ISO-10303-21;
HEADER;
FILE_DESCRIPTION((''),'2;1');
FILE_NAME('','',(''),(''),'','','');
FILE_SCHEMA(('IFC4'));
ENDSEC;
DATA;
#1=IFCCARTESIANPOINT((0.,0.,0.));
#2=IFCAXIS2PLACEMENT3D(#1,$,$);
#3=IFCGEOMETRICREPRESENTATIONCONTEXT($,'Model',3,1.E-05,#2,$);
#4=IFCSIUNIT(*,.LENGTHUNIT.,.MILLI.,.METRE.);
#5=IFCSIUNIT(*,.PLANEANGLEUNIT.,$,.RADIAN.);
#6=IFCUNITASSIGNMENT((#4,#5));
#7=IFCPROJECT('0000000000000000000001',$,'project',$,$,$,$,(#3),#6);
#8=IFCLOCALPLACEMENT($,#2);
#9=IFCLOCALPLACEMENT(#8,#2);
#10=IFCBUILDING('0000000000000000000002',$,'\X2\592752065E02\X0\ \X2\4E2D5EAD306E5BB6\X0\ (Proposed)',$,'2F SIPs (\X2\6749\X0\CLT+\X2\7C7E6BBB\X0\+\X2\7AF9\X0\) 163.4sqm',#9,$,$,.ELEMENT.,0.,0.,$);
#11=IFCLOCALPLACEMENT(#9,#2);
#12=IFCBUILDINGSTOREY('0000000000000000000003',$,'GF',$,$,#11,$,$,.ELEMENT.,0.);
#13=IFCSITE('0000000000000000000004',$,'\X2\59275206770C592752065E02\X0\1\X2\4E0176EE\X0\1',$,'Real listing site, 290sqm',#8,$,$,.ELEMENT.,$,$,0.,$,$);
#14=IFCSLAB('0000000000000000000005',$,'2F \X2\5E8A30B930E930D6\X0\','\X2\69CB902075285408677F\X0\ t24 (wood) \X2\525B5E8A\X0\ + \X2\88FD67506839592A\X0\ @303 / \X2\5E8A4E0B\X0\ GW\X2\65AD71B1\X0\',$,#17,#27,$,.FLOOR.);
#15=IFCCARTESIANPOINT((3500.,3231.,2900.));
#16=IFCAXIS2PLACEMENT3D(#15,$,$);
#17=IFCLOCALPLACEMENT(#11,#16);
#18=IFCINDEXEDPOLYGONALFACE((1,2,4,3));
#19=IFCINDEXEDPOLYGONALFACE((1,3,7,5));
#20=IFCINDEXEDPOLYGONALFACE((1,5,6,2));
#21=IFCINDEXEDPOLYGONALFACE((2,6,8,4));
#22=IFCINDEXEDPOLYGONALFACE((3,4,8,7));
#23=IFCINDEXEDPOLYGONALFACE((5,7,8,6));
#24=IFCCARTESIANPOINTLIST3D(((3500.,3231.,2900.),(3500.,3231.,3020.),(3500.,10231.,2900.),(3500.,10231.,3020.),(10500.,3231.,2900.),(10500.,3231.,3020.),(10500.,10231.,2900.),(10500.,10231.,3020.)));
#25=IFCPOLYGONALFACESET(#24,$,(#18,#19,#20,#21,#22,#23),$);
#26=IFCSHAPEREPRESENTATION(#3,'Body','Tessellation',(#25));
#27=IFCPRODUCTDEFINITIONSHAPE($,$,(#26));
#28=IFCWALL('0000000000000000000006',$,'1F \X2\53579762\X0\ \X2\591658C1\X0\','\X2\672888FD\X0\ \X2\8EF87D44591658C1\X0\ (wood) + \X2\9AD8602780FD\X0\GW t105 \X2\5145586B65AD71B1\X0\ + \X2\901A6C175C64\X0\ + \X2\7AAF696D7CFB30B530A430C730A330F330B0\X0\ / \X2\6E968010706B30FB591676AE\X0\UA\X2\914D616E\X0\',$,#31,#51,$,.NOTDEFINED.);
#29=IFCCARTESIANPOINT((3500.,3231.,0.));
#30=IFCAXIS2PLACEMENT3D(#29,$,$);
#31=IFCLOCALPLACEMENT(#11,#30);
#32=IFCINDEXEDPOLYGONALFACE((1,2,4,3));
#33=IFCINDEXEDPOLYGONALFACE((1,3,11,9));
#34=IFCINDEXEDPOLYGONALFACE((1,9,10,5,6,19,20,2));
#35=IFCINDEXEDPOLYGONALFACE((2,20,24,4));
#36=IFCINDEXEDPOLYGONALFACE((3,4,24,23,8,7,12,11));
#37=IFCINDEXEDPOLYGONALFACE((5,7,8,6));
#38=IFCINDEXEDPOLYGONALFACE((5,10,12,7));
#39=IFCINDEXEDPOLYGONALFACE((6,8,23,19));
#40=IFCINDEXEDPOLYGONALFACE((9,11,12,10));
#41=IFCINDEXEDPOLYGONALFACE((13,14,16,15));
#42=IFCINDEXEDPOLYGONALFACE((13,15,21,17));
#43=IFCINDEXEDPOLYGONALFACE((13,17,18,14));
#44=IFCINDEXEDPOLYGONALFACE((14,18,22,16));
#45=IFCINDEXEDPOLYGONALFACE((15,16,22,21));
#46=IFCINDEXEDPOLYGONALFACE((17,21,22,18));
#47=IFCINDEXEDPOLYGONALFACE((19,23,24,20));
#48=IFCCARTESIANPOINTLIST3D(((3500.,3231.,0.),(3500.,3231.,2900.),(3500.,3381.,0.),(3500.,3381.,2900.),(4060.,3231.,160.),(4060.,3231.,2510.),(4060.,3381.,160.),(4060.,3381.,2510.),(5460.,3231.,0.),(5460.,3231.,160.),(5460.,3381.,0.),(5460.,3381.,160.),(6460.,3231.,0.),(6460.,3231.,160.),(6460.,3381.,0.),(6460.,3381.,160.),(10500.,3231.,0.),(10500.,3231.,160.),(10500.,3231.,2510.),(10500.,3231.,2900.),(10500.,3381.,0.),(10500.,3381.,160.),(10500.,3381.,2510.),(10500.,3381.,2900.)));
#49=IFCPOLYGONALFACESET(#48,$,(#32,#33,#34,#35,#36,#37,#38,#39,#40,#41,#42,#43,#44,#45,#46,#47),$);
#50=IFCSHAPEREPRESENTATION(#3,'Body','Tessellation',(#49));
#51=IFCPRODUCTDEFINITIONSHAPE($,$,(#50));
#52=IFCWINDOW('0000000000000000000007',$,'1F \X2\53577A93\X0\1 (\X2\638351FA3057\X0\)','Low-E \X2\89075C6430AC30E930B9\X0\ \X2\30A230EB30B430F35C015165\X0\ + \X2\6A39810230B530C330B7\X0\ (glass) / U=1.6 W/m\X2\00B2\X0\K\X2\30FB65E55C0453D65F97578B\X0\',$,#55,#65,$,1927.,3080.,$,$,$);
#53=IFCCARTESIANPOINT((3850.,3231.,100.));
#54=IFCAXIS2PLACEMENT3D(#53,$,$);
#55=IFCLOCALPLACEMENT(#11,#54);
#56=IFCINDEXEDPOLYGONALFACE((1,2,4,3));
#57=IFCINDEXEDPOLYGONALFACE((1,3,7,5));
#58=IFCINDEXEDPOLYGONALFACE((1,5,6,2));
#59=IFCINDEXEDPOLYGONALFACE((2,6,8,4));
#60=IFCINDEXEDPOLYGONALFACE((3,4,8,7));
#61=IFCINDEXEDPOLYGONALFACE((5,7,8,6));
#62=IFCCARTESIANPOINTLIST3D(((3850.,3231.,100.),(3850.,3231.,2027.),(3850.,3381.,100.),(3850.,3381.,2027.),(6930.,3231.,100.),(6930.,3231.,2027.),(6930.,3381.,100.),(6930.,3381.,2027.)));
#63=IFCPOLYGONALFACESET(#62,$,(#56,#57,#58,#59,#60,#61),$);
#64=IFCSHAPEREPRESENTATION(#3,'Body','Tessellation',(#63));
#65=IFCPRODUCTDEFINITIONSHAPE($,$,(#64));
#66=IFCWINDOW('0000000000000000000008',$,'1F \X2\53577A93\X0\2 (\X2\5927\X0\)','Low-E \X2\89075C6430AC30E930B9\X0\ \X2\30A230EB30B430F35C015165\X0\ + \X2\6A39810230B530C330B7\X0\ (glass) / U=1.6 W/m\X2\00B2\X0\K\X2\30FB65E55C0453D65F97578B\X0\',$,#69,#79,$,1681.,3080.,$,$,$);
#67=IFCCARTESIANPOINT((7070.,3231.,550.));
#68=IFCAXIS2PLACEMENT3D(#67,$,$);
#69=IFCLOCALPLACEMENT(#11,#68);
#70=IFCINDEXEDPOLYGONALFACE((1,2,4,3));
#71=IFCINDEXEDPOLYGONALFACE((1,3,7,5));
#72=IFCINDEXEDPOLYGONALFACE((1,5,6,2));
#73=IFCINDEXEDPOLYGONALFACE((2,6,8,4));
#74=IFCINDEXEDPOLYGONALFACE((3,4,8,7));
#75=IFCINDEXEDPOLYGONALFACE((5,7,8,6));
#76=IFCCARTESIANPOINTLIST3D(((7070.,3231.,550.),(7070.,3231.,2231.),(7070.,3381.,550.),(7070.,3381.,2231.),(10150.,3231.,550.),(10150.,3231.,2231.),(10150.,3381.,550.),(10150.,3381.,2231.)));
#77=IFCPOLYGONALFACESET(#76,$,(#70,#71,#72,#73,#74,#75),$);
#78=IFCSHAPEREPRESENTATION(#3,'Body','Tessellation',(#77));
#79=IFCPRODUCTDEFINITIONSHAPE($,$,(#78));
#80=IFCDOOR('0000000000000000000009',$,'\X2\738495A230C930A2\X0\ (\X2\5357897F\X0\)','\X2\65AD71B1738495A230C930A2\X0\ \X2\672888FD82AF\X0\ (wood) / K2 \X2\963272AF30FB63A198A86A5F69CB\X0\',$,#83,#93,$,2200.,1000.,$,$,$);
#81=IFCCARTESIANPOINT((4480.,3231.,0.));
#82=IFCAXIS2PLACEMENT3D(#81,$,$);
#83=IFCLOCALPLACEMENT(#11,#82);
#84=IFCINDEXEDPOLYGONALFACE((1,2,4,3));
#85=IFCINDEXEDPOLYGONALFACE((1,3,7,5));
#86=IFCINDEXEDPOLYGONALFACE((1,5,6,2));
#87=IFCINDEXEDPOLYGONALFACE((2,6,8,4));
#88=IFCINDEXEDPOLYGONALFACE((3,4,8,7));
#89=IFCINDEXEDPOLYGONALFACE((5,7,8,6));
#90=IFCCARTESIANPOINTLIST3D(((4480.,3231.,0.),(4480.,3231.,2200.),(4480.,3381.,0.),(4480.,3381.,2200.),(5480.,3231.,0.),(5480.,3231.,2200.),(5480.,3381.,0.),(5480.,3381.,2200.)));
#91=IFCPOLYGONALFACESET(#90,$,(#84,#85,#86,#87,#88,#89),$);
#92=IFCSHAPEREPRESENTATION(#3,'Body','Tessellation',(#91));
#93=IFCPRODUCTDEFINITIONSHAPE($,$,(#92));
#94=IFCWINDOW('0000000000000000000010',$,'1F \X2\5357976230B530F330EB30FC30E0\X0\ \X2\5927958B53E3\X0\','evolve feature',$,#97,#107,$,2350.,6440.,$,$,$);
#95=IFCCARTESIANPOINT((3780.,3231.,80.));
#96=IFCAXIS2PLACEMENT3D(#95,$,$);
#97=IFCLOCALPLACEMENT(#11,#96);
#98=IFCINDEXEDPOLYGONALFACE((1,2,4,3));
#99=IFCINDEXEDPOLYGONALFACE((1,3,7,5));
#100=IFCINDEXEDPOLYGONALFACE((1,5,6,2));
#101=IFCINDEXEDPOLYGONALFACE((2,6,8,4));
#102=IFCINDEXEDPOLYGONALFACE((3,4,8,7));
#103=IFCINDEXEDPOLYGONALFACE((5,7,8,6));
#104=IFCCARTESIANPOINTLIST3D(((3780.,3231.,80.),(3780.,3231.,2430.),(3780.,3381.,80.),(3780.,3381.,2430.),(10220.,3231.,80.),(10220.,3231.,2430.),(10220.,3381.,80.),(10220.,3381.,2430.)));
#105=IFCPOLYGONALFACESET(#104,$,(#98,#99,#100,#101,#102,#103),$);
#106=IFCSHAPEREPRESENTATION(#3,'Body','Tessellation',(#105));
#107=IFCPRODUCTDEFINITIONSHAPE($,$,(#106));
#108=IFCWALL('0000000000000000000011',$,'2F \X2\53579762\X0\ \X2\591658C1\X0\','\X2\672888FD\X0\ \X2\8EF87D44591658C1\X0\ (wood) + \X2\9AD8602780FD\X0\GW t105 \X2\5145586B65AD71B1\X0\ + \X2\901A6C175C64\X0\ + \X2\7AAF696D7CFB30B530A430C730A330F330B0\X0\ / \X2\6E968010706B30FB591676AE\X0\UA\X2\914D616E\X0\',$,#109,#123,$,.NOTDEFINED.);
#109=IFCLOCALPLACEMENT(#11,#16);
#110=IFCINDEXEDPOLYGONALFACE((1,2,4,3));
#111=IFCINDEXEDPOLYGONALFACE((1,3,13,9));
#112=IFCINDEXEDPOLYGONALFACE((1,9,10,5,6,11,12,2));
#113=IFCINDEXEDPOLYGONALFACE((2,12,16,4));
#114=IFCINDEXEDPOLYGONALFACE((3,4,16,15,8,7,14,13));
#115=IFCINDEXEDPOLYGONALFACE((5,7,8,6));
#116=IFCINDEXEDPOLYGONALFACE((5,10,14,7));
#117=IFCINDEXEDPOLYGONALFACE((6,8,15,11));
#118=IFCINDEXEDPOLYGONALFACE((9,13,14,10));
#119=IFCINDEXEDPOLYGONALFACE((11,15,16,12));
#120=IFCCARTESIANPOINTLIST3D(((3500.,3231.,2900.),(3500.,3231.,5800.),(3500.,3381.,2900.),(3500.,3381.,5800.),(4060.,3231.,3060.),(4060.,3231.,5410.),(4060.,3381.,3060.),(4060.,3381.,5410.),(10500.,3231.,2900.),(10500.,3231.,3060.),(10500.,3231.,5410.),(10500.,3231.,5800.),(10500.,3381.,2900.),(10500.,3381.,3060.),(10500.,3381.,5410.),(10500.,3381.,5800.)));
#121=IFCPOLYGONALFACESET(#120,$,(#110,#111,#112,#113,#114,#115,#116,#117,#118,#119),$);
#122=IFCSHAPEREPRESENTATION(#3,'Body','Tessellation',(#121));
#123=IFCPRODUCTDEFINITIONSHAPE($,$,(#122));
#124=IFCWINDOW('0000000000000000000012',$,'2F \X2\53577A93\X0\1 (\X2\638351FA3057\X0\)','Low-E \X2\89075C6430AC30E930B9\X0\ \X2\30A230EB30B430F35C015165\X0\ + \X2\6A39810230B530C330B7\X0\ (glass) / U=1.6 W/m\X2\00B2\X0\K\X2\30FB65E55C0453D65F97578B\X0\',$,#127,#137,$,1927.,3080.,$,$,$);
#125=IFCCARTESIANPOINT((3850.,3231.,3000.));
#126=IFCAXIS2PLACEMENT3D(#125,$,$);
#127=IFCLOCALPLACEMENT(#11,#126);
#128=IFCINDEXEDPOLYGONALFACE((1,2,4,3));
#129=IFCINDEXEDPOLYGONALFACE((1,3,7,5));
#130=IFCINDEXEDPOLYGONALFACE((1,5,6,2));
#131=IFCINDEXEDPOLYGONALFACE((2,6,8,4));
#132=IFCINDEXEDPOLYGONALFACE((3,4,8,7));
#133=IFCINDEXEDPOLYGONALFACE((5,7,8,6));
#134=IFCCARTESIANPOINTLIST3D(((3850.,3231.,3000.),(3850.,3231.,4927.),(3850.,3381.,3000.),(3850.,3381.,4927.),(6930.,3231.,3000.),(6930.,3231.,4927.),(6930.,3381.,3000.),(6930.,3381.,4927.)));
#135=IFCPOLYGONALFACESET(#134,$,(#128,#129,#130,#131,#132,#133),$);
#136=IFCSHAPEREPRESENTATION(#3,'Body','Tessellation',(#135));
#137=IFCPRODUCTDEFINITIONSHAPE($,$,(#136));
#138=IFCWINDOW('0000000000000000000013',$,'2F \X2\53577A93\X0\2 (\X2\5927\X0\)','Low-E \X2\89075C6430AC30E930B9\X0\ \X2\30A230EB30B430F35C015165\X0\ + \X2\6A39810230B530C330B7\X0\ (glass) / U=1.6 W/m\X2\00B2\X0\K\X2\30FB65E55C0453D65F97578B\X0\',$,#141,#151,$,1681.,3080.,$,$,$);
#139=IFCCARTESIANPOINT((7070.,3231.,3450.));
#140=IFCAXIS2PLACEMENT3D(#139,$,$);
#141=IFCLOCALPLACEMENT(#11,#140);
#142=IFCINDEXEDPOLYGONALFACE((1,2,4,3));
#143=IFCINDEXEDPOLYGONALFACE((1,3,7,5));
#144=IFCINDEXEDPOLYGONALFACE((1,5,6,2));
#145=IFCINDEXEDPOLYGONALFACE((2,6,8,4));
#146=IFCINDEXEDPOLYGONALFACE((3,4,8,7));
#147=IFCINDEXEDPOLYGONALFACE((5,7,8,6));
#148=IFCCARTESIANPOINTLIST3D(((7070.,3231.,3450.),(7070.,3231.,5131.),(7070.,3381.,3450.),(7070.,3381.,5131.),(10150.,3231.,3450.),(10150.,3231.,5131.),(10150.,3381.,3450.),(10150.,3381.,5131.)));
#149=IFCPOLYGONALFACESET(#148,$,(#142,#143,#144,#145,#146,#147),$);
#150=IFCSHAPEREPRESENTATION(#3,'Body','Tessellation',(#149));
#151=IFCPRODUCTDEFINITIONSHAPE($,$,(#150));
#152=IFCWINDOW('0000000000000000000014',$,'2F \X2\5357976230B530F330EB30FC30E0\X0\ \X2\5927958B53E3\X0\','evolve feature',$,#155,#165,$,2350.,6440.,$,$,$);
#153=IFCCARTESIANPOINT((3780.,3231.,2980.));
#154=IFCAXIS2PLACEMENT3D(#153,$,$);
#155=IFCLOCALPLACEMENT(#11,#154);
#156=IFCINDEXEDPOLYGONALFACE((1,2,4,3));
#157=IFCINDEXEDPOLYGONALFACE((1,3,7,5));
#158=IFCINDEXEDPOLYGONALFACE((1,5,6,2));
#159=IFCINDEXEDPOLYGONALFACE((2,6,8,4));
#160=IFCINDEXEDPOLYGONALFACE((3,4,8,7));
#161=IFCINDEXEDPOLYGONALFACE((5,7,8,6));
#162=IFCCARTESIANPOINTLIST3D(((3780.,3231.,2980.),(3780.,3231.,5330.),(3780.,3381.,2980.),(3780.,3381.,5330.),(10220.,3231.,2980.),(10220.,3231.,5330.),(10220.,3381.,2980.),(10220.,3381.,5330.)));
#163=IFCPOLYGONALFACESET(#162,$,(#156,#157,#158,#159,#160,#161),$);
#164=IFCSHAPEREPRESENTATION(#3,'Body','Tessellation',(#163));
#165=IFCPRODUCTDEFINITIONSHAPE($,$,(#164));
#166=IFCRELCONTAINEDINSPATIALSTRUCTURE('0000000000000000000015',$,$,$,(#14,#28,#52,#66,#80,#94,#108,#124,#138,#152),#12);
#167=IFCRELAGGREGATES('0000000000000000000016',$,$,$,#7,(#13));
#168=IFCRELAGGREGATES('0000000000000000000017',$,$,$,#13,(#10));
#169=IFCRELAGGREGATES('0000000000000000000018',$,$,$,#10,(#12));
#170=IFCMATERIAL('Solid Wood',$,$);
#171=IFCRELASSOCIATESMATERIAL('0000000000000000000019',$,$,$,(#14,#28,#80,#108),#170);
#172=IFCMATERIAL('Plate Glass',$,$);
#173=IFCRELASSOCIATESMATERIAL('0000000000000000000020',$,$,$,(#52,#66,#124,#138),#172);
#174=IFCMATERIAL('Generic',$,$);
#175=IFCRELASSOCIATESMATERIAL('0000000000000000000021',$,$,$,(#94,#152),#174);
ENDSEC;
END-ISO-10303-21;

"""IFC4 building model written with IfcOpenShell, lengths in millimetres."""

from ifc_helpers import new_model, si_unit, frame, frame_2d, origin, place, context, project, spatial, rectangle, extrude, material, element, fill, save


model = new_model("IFC4")

# Units and contexts
model_context = context("Model", 3, precision=1e-05, world=origin())
ifc_project = project(units=[si_unit("LENGTHUNIT", "METRE", prefix="MILLI"), si_unit("PLANEANGLEUNIT", "RADIAN")], contexts=[model_context])

# Site, building, storey
site_placement = place(None, origin())
site = spatial("IfcSite", under=ifc_project, at=site_placement, Name="大分県大分市1丁目1", ObjectType="Real listing site, 290sqm", CompositionType="ELEMENT", RefElevation=0.0)
building_placement = place(site_placement, origin())
building = spatial("IfcBuilding", under=site, at=building_placement, Name="大分市 中庭の家 (Proposed)", ObjectType="2F SIPs (杉CLT+籾殻+竹) 163.4sqm", CompositionType="ELEMENT", ElevationOfRefHeight=0.0, ElevationOfTerrain=0.0)
storey_placement = place(building_placement, origin())
storey = spatial("IfcBuildingStorey", under=building, at=storey_placement, Name="GF", CompositionType="ELEMENT", Elevation=0.0)

# Slab
ifc_material_1 = material(Name="Solid Wood")
slab_1_placement = place(storey_placement, frame((3500.0, 3231.0, 2900.0)))
element("IfcSlab", 1, at=slab_1_placement, inside=storey, material=ifc_material_1, Name="2F 床スラブ", Description="構造用合板 t24 (wood) 剛床 + 製材根太 @303 / 床下 GW断熱", PredefinedType="FLOOR", context=model_context, shape_type="SweptSolid", body=[
    extrude(rectangle(XDim=7000.0, YDim=7000.0, at=frame_2d((3500.0, 3500.0))), frame((3500.0, 3231.0, 2900.0)), (0.0, 0.0, 1.0), 120.0),
])
ifc_material_2 = material(Name="Generic")

# Wall, openings, windows, door
wall_1_placement = place(storey_placement, frame((3500.0, 3231.0, 0.0)))
wall_1 = element("IfcWall", 2, at=wall_1_placement, inside=storey, material=ifc_material_1, Name="1F 南面 外壁", Description="木製 軸組外壁 (wood) + 高性能GW t105 充填断熱 + 通気層 + 窯業系サイディング / 準耐火・外皮UA配慮", PredefinedType="NOTDEFINED", context=model_context, shape_type="SweptSolid", body=[
    extrude(rectangle(XDim=7000.0, YDim=150.0, at=frame_2d((3500.0, 75.0))), frame((3500.0, 3231.0, 0.0)), (0.0, 0.0, 1.0), 2900.0),
])
opening_1_placement = place(storey_placement, frame((3850.0, 3231.0, 100.0)))
opening_1 = element("IfcOpeningElement", 3, at=opening_1_placement, cuts=wall_1, PredefinedType="NOTDEFINED", context=model_context, shape_type="SweptSolid", body=[
    extrude(rectangle(XDim=3080.0, YDim=150.0, at=frame_2d((1540.0, 75.0))), frame((3850.0, 3231.0, 100.0)), (0.0, 0.0, 1.0), 1927.0),
])
opening_2_placement = place(storey_placement, frame((7070.0, 3231.0, 550.0)))
opening_2 = element("IfcOpeningElement", 4, at=opening_2_placement, cuts=wall_1, PredefinedType="NOTDEFINED", context=model_context, shape_type="SweptSolid", body=[
    extrude(rectangle(XDim=3080.0, YDim=150.0, at=frame_2d((1540.0, 75.0))), frame((7070.0, 3231.0, 550.0)), (0.0, 0.0, 1.0), 1681.0),
])
opening_3_placement = place(storey_placement, frame((4480.0, 3231.0, 0.0)))
opening_3 = element("IfcOpeningElement", 5, at=opening_3_placement, cuts=wall_1, PredefinedType="NOTDEFINED", context=model_context, shape_type="SweptSolid", body=[
    extrude(rectangle(XDim=1000.0, YDim=150.0, at=frame_2d((500.0, 75.0))), frame((4480.0, 3231.0, 0.0)), (0.0, 0.0, 1.0), 2200.0),
])
opening_4_placement = place(storey_placement, frame((3780.0, 3231.0, 80.0)))
opening_4 = element("IfcOpeningElement", 6, at=opening_4_placement, cuts=wall_1, PredefinedType="NOTDEFINED", context=model_context, shape_type="SweptSolid", body=[
    extrude(rectangle(XDim=6440.0, YDim=150.0, at=frame_2d((3220.0, 75.0))), frame((3780.0, 3231.0, 80.0)), (0.0, 0.0, 1.0), 2350.0),
])
ifc_material_3 = material(Name="Plate Glass")
window_1_placement = place(storey_placement, frame((3850.0, 3231.0, 100.0)))
window_1 = element("IfcWindow", 7, at=window_1_placement, inside=storey, material=ifc_material_3, Name="1F 南窓1 (掃出し)", Description="Low-E 複層ガラス アルゴン封入 + 樹脂サッシ (glass) / U=1.6 W/m²K・日射取得型", OverallHeight=1927.0, OverallWidth=3080.0, context=model_context, shape_type="SweptSolid", body=[
    extrude(rectangle(XDim=3080.0, YDim=150.0, at=frame_2d((1540.0, 75.0))), frame((3850.0, 3231.0, 100.0)), (0.0, 0.0, 1.0), 1927.0),
])
fill(opening_1, window_1)
window_2_placement = place(storey_placement, frame((7070.0, 3231.0, 550.0)))
window_2 = element("IfcWindow", 8, at=window_2_placement, inside=storey, material=ifc_material_3, Name="1F 南窓2 (大)", Description="Low-E 複層ガラス アルゴン封入 + 樹脂サッシ (glass) / U=1.6 W/m²K・日射取得型", OverallHeight=1681.0, OverallWidth=3080.0, context=model_context, shape_type="SweptSolid", body=[
    extrude(rectangle(XDim=3080.0, YDim=150.0, at=frame_2d((1540.0, 75.0))), frame((7070.0, 3231.0, 550.0)), (0.0, 0.0, 1.0), 1681.0),
])
fill(opening_2, window_2)
door_placement = place(storey_placement, frame((4480.0, 3231.0, 0.0)))
door = element("IfcDoor", 9, at=door_placement, inside=storey, material=ifc_material_1, Name="玄関ドア (南西)", Description="断熱玄関ドア 木製芯 (wood) / K2 防犯・採風機構", OverallHeight=2200.0, OverallWidth=1000.0, context=model_context, shape_type="SweptSolid", body=[
    extrude(rectangle(XDim=1000.0, YDim=150.0, at=frame_2d((500.0, 75.0))), frame((4480.0, 3231.0, 0.0)), (0.0, 0.0, 1.0), 2200.0),
])
fill(opening_3, door)
window_3_placement = place(storey_placement, frame((3780.0, 3231.0, 80.0)))
window_3 = element("IfcWindow", 10, at=window_3_placement, inside=storey, material=ifc_material_2, Name="1F 南面サンルーム 大開口", Description="evolve feature", OverallHeight=2350.0, OverallWidth=6440.0, context=model_context, shape_type="SweptSolid", body=[
    extrude(rectangle(XDim=6440.0, YDim=150.0, at=frame_2d((3220.0, 75.0))), frame((3780.0, 3231.0, 80.0)), (0.0, 0.0, 1.0), 2350.0),
])
fill(opening_4, window_3)

# Wall, openings, windows
wall_2_placement = place(storey_placement, frame((3500.0, 3231.0, 2900.0)))
wall_2 = element("IfcWall", 11, at=wall_2_placement, inside=storey, material=ifc_material_1, Name="2F 南面 外壁", Description="木製 軸組外壁 (wood) + 高性能GW t105 充填断熱 + 通気層 + 窯業系サイディング / 準耐火・外皮UA配慮", PredefinedType="NOTDEFINED", context=model_context, shape_type="SweptSolid", body=[
    extrude(rectangle(XDim=7000.0, YDim=150.0, at=frame_2d((3500.0, 75.0))), frame((3500.0, 3231.0, 2900.0)), (0.0, 0.0, 1.0), 2900.0),
])
opening_5_placement = place(storey_placement, frame((3850.0, 3231.0, 3000.0)))
opening_5 = element("IfcOpeningElement", 12, at=opening_5_placement, cuts=wall_2, PredefinedType="NOTDEFINED", context=model_context, shape_type="SweptSolid", body=[
    extrude(rectangle(XDim=3080.0, YDim=150.0, at=frame_2d((1540.0, 75.0))), frame((3850.0, 3231.0, 3000.0)), (0.0, 0.0, 1.0), 1927.0),
])
opening_6_placement = place(storey_placement, frame((7070.0, 3231.0, 3450.0)))
opening_6 = element("IfcOpeningElement", 13, at=opening_6_placement, cuts=wall_2, PredefinedType="NOTDEFINED", context=model_context, shape_type="SweptSolid", body=[
    extrude(rectangle(XDim=3080.0, YDim=150.0, at=frame_2d((1540.0, 75.0))), frame((7070.0, 3231.0, 3450.0)), (0.0, 0.0, 1.0), 1681.0),
])
opening_7_placement = place(storey_placement, frame((3780.0, 3231.0, 2980.0)))
opening_7 = element("IfcOpeningElement", 14, at=opening_7_placement, cuts=wall_2, PredefinedType="NOTDEFINED", context=model_context, shape_type="SweptSolid", body=[
    extrude(rectangle(XDim=6440.0, YDim=150.0, at=frame_2d((3220.0, 75.0))), frame((3780.0, 3231.0, 2980.0)), (0.0, 0.0, 1.0), 2350.0),
])
window_4_placement = place(storey_placement, frame((3850.0, 3231.0, 3000.0)))
window_4 = element("IfcWindow", 15, at=window_4_placement, inside=storey, material=ifc_material_3, Name="2F 南窓1 (掃出し)", Description="Low-E 複層ガラス アルゴン封入 + 樹脂サッシ (glass) / U=1.6 W/m²K・日射取得型", OverallHeight=1927.0, OverallWidth=3080.0, context=model_context, shape_type="SweptSolid", body=[
    extrude(rectangle(XDim=3080.0, YDim=150.0, at=frame_2d((1540.0, 75.0))), frame((3850.0, 3231.0, 3000.0)), (0.0, 0.0, 1.0), 1927.0),
])
fill(opening_5, window_4)
window_5_placement = place(storey_placement, frame((7070.0, 3231.0, 3450.0)))
window_5 = element("IfcWindow", 16, at=window_5_placement, inside=storey, material=ifc_material_3, Name="2F 南窓2 (大)", Description="Low-E 複層ガラス アルゴン封入 + 樹脂サッシ (glass) / U=1.6 W/m²K・日射取得型", OverallHeight=1681.0, OverallWidth=3080.0, context=model_context, shape_type="SweptSolid", body=[
    extrude(rectangle(XDim=3080.0, YDim=150.0, at=frame_2d((1540.0, 75.0))), frame((7070.0, 3231.0, 3450.0)), (0.0, 0.0, 1.0), 1681.0),
])
fill(opening_6, window_5)
window_6_placement = place(storey_placement, frame((3780.0, 3231.0, 2980.0)))
window_6 = element("IfcWindow", 17, at=window_6_placement, inside=storey, material=ifc_material_2, Name="2F 南面サンルーム 大開口", Description="evolve feature", OverallHeight=2350.0, OverallWidth=6440.0, context=model_context, shape_type="SweptSolid", body=[
    extrude(rectangle(XDim=6440.0, YDim=150.0, at=frame_2d((3220.0, 75.0))), frame((3780.0, 3231.0, 2980.0)), (0.0, 0.0, 1.0), 2350.0),
])
fill(opening_7, window_6)

save(model, "model.ifc")
